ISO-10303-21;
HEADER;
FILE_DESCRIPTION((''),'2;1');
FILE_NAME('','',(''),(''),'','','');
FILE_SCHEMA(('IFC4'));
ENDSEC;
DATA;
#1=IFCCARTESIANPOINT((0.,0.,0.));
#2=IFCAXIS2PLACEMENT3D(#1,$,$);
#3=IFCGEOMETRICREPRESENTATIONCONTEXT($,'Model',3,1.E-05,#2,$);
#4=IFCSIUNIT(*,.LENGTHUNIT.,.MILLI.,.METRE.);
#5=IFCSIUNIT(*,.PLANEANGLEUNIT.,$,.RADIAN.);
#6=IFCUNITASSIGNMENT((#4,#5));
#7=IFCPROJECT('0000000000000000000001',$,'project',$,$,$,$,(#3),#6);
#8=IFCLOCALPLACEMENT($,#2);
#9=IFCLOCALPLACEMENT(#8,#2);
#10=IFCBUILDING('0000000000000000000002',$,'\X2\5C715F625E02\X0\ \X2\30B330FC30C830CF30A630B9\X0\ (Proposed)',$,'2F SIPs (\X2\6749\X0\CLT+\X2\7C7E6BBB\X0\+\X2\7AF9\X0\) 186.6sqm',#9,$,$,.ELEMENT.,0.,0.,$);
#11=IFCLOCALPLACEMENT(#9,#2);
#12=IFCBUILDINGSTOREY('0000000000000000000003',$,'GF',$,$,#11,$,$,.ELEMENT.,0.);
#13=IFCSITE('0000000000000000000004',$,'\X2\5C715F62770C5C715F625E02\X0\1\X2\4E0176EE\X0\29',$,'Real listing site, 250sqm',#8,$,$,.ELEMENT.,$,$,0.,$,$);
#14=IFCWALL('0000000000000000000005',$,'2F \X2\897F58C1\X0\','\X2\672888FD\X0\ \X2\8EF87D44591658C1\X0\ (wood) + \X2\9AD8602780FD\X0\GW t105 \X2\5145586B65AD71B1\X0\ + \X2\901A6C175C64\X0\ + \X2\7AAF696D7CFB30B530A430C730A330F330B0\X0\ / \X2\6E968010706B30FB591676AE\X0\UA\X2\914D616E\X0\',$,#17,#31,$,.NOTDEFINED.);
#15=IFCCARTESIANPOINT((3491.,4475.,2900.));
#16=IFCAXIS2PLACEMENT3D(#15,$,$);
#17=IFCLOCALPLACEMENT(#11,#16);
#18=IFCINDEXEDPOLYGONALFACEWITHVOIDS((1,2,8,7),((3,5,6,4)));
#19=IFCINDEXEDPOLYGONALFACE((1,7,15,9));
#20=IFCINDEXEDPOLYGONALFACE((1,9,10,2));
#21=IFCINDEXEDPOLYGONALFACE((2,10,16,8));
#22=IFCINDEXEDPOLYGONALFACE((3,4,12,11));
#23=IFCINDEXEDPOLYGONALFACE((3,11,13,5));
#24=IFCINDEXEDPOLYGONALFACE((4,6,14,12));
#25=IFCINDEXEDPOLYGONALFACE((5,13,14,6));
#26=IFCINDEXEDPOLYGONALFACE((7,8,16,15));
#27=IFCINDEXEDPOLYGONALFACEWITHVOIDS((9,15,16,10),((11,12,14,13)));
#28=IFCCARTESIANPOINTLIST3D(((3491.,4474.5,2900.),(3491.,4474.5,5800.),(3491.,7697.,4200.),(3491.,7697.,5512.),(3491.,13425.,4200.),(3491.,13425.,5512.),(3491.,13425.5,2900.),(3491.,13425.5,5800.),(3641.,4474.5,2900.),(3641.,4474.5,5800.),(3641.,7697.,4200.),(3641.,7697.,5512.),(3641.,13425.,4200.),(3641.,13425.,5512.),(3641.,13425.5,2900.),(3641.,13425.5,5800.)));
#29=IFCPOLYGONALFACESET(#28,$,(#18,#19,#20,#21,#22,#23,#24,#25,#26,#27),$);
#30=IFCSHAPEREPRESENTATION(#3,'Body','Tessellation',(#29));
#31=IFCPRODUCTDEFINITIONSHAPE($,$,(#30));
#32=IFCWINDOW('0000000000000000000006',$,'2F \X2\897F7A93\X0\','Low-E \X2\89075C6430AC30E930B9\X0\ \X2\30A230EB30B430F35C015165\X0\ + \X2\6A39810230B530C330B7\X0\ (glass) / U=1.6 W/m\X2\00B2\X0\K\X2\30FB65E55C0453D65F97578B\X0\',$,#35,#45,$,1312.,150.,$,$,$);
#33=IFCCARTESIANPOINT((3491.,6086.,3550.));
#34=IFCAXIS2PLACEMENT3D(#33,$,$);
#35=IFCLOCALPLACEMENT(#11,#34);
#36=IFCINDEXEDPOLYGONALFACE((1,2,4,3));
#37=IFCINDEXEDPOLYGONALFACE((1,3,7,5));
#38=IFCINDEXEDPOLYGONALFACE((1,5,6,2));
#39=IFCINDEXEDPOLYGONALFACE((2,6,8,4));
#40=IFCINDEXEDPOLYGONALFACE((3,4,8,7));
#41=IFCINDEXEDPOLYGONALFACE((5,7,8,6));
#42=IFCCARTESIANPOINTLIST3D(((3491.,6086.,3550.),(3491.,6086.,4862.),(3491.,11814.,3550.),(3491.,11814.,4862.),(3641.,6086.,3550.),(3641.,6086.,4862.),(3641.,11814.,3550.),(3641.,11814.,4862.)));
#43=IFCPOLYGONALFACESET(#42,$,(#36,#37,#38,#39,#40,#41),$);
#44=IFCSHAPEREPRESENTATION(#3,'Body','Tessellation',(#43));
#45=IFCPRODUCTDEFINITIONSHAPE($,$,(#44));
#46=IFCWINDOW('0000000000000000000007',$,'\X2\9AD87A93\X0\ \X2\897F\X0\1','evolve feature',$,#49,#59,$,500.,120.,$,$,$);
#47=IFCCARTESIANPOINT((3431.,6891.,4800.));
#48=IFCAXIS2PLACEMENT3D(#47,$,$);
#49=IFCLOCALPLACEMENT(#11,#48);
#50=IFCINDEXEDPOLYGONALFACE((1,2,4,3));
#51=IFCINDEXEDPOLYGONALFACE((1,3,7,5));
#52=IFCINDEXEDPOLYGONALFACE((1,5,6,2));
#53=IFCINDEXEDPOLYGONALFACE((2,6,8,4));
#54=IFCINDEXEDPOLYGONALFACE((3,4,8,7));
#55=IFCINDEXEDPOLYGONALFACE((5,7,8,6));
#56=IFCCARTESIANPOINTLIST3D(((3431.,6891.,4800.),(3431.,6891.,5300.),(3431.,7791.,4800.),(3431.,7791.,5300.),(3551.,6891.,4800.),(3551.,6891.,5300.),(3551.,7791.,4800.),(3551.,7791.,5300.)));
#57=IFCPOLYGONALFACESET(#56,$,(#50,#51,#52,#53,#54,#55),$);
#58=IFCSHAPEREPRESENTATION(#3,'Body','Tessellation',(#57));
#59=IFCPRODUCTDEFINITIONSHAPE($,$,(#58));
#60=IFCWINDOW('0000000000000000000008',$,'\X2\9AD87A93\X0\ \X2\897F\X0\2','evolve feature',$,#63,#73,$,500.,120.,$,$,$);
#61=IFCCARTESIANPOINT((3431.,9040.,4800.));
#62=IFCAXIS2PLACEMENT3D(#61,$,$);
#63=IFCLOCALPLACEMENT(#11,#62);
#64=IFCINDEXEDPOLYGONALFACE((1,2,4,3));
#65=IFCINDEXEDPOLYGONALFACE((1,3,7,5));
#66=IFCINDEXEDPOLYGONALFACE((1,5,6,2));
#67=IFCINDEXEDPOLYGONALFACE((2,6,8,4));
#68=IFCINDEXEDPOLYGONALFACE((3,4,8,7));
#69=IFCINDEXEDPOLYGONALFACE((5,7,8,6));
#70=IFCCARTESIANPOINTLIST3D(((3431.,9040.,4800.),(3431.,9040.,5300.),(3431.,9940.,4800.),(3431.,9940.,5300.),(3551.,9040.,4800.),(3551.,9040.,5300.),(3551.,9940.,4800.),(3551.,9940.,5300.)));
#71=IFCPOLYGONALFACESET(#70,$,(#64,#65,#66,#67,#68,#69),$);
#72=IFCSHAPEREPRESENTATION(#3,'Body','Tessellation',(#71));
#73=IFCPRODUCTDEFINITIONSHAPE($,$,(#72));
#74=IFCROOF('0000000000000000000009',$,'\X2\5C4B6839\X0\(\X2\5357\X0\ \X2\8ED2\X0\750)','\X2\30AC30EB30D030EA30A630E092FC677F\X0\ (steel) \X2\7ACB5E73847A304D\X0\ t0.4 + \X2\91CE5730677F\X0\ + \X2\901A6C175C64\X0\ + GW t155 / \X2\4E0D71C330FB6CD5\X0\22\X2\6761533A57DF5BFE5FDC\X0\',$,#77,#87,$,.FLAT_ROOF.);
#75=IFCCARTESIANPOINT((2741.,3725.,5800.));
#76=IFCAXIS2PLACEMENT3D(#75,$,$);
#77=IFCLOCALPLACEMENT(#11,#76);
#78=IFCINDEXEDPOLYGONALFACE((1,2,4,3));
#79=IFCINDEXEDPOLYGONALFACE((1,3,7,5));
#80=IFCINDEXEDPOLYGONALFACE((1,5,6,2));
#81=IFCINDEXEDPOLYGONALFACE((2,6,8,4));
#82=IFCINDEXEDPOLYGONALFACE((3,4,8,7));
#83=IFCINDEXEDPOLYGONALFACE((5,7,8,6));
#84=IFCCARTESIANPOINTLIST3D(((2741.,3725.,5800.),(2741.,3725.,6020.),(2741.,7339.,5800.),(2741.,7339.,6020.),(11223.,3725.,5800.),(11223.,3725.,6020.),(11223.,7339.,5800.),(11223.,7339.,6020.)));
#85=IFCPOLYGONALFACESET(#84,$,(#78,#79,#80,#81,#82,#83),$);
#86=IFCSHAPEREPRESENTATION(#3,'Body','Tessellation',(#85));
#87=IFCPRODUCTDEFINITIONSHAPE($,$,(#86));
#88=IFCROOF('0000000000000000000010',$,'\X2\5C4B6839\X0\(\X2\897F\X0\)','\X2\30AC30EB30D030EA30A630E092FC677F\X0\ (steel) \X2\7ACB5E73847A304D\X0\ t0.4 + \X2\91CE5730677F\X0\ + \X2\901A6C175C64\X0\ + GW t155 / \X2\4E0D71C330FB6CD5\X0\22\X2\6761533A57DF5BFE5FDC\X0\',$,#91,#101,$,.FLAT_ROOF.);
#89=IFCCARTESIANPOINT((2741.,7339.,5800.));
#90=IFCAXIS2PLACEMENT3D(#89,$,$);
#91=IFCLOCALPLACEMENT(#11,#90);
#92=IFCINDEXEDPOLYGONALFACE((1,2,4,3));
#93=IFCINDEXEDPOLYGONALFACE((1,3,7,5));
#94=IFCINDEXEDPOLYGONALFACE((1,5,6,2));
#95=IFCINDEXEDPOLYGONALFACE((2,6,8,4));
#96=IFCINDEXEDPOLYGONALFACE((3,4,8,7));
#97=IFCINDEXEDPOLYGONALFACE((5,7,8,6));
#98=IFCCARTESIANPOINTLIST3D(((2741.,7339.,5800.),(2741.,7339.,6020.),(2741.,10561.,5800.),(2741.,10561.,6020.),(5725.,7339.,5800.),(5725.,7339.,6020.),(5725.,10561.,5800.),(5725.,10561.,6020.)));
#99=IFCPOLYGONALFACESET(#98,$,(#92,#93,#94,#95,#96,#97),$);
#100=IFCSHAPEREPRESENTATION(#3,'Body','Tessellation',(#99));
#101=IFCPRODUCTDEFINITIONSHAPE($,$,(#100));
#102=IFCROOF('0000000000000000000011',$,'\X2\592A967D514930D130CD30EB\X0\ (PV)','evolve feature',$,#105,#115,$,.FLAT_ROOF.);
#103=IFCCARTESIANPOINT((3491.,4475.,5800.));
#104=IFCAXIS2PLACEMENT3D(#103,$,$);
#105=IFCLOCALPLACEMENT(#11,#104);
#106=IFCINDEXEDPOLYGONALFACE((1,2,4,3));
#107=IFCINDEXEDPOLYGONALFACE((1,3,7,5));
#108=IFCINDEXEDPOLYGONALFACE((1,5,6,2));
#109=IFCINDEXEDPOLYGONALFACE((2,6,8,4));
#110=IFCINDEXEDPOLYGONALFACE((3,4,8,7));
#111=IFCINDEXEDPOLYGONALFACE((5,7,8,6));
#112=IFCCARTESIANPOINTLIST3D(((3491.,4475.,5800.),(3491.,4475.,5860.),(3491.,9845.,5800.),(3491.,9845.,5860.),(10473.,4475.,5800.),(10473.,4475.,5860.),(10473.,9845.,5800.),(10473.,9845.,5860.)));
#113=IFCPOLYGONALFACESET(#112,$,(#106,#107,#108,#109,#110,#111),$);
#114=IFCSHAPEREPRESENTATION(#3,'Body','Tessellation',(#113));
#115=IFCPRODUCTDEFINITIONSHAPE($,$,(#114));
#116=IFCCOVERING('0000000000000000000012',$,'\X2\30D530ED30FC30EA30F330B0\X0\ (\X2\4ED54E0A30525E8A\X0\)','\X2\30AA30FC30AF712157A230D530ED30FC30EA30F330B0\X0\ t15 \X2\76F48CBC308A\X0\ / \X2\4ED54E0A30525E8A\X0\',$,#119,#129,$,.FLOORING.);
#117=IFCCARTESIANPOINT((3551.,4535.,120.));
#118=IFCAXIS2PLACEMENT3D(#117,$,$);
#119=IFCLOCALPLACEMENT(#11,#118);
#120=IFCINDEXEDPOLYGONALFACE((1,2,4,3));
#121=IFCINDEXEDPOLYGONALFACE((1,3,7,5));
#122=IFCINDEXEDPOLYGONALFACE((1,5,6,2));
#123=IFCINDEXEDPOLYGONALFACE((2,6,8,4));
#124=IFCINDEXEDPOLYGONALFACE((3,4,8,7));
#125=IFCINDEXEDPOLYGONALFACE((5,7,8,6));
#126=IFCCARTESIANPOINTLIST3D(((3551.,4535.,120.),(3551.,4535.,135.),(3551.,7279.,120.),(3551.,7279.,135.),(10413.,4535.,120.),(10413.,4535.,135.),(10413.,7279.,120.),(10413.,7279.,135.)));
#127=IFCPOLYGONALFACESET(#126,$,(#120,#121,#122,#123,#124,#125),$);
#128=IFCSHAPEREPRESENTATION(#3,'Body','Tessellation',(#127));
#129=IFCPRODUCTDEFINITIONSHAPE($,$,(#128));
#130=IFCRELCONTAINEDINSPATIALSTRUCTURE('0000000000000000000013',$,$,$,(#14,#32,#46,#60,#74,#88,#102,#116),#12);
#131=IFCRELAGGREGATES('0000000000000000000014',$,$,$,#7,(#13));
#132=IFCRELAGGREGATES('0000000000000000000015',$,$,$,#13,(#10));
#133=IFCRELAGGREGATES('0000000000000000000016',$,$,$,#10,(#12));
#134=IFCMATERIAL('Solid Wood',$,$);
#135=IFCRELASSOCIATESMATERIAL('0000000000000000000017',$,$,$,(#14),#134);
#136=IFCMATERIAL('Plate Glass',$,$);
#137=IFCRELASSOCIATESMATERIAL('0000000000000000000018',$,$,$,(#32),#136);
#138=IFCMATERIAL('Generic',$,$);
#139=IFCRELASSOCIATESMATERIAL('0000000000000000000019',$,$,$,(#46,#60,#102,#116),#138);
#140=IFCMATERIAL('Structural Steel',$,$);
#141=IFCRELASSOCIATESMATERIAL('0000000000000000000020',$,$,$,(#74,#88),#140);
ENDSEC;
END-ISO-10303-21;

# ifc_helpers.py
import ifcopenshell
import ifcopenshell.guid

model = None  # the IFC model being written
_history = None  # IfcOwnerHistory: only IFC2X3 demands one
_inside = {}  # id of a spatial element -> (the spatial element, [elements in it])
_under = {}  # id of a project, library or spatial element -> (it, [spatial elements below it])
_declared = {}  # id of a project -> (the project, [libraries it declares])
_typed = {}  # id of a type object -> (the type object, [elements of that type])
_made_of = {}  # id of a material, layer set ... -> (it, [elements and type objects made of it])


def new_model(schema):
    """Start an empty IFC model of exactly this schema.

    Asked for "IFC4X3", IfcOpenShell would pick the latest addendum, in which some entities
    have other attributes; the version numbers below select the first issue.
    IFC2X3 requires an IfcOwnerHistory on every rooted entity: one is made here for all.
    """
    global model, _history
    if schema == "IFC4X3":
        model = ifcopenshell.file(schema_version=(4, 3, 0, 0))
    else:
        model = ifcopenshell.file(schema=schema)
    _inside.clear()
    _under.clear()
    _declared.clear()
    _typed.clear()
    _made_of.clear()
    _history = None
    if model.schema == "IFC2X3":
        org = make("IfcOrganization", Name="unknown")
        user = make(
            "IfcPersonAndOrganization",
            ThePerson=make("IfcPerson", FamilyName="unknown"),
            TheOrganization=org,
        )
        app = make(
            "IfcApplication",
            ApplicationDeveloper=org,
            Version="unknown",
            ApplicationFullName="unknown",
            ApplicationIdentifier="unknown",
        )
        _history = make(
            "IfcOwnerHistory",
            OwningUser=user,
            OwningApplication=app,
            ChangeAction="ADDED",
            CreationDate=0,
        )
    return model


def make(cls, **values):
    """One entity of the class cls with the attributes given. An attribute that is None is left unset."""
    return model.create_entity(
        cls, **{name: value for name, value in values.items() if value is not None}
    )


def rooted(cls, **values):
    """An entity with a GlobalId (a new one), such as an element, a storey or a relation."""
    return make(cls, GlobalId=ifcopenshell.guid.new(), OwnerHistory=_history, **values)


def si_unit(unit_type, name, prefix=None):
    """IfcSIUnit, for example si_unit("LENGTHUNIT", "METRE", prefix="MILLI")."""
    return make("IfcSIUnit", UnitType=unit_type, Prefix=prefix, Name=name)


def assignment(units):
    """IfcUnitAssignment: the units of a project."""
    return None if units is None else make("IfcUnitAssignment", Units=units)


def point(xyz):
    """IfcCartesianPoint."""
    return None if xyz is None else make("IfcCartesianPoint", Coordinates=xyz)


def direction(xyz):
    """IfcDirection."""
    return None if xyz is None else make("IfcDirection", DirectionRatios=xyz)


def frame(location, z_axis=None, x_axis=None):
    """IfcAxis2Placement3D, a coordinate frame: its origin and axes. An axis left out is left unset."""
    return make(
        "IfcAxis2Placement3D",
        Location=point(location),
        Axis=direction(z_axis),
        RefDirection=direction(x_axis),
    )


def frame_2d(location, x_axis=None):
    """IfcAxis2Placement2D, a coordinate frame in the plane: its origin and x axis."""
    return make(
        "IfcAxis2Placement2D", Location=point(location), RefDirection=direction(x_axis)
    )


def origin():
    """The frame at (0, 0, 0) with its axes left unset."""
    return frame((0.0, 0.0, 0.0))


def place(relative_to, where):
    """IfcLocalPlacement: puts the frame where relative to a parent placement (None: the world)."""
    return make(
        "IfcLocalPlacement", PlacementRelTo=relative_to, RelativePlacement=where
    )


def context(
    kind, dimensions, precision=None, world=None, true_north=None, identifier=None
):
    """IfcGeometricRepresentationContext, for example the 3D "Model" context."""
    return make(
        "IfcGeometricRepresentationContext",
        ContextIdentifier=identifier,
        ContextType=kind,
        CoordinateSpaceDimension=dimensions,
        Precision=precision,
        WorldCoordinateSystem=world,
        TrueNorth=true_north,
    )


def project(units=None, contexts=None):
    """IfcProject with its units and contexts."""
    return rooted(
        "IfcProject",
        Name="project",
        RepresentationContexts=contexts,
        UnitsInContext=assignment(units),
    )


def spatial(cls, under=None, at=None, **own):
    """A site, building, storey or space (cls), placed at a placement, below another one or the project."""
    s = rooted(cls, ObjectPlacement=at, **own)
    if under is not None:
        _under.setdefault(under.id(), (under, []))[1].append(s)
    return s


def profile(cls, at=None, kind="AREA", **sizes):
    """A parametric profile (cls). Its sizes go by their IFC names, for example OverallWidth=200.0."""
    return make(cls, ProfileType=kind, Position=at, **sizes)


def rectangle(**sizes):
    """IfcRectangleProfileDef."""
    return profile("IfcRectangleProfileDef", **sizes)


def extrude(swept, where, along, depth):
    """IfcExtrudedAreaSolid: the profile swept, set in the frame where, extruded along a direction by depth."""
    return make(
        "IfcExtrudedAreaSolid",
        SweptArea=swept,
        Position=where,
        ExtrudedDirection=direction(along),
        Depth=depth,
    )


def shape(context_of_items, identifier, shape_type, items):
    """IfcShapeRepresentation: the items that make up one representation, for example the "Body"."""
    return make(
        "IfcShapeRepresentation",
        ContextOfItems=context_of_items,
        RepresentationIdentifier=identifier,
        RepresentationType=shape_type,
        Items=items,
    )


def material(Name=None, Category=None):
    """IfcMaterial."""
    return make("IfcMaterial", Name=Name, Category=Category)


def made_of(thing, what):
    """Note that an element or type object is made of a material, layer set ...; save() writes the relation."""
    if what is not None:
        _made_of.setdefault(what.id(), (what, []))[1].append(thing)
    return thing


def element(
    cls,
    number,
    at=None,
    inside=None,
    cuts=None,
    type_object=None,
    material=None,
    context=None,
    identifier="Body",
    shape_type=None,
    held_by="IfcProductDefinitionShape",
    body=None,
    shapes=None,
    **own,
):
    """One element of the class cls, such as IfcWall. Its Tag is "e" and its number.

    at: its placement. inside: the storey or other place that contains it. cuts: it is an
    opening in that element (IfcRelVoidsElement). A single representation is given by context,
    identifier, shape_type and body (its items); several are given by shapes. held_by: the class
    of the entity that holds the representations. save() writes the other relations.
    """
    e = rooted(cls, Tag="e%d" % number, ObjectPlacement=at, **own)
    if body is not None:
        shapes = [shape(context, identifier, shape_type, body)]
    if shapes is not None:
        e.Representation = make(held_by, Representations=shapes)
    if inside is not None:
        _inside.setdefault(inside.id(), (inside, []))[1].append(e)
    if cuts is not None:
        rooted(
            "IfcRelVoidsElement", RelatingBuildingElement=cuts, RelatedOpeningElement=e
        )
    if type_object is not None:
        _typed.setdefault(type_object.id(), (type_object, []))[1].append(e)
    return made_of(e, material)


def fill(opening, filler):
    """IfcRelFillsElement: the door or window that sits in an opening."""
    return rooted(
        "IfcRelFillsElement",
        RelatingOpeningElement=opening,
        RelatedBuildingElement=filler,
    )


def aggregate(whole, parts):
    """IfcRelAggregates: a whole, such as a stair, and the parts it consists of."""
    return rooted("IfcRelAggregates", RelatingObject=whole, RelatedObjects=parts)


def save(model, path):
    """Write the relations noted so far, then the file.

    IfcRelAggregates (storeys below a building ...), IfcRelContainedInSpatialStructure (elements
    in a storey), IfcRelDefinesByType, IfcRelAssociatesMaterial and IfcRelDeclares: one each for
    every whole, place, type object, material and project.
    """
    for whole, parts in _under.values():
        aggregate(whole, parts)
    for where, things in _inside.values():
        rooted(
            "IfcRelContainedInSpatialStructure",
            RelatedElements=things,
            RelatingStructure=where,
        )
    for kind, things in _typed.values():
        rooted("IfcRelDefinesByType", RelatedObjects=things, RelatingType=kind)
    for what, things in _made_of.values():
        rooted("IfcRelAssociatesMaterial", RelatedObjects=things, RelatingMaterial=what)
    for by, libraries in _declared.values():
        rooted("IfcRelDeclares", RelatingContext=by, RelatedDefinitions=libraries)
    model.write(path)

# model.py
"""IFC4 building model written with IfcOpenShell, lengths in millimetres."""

from ifc_helpers import new_model, si_unit, frame, frame_2d, origin, place, context, project, spatial, rectangle, extrude, material, element, fill, save


model = new_model("IFC4")

# Units and contexts
model_context = context("Model", 3, precision=1e-05, world=origin())
ifc_project = project(units=[si_unit("LENGTHUNIT", "METRE", prefix="MILLI"), si_unit("PLANEANGLEUNIT", "RADIAN")], contexts=[model_context])

# Site, building, storey
site_placement = place(None, origin())
site = spatial("IfcSite", under=ifc_project, at=site_placement, Name="山形県山形市1丁目29", ObjectType="Real listing site, 250sqm", CompositionType="ELEMENT", RefElevation=0.0)
building_placement = place(site_placement, origin())
building = spatial("IfcBuilding", under=site, at=building_placement, Name="山形市 コートハウス (Proposed)", ObjectType="2F SIPs (杉CLT+籾殻+竹) 186.6sqm", CompositionType="ELEMENT", ElevationOfRefHeight=0.0, ElevationOfTerrain=0.0)
storey_placement = place(building_placement, origin())
storey = spatial("IfcBuildingStorey", under=building, at=storey_placement, Name="GF", CompositionType="ELEMENT", Elevation=0.0)

# Shared definitions
ifc_material_1 = material(Name="Solid Wood")
ifc_material_2 = material(Name="Generic")

# Shared definitions
ifc_material_3 = material(Name="Plate Glass")

# Wall, openings, windows
wall_1_placement = place(storey_placement, frame((3491.0, 4475.0, 2900.0)))
wall_1 = element("IfcWall", 1, at=wall_1_placement, inside=storey, material=ifc_material_1, Name="2F 西壁", Description="木製 軸組外壁 (wood) + 高性能GW t105 充填断熱 + 通気層 + 窯業系サイディング / 準耐火・外皮UA配慮", PredefinedType="NOTDEFINED", context=model_context, shape_type="SweptSolid", body=[
    extrude(rectangle(XDim=150.0, YDim=8951.0, at=frame_2d((75.0, 4475.0))), frame((3491.0, 4475.0, 2900.0)), (0.0, 0.0, 1.0), 2900.0),
])
opening_1_placement = place(storey_placement, frame((3491.0, 6086.0, 3550.0)))
opening_1 = element("IfcOpeningElement", 2, at=opening_1_placement, cuts=wall_1, PredefinedType="NOTDEFINED", context=model_context, shape_type="SweptSolid", body=[
    extrude(rectangle(XDim=150.0, YDim=5728.0, at=frame_2d((75.0, 2864.0))), frame((3491.0, 6086.0, 3550.0)), (0.0, 0.0, 1.0), 1312.0),
])
opening_2_placement = place(storey_placement, frame((3431.0, 6891.0, 4800.0)))
opening_2 = element("IfcOpeningElement", 3, at=opening_2_placement, cuts=wall_1, PredefinedType="NOTDEFINED", context=model_context, shape_type="SweptSolid", body=[
    extrude(rectangle(XDim=120.0, YDim=900.0, at=frame_2d((60.0, 450.0))), frame((3431.0, 6891.0, 4800.0)), (0.0, 0.0, 1.0), 500.0),
])
opening_3_placement = place(storey_placement, frame((3431.0, 9040.0, 4800.0)))
opening_3 = element("IfcOpeningElement", 4, at=opening_3_placement, cuts=wall_1, PredefinedType="NOTDEFINED", context=model_context, shape_type="SweptSolid", body=[
    extrude(rectangle(XDim=120.0, YDim=900.0, at=frame_2d((60.0, 450.0))), frame((3431.0, 9040.0, 4800.0)), (0.0, 0.0, 1.0), 500.0),
])
window_1_placement = place(storey_placement, frame((3491.0, 6086.0, 3550.0)))
window_1 = element("IfcWindow", 5, at=window_1_placement, inside=storey, material=ifc_material_3, Name="2F 西窓", Description="Low-E 複層ガラス アルゴン封入 + 樹脂サッシ (glass) / U=1.6 W/m²K・日射取得型", OverallHeight=1312.0, OverallWidth=150.0, context=model_context, shape_type="SweptSolid", body=[
    extrude(rectangle(XDim=150.0, YDim=5728.0, at=frame_2d((75.0, 2864.0))), frame((3491.0, 6086.0, 3550.0)), (0.0, 0.0, 1.0), 1312.0),
])
fill(opening_1, window_1)
window_2_placement = place(storey_placement, frame((3431.0, 6891.0, 4800.0)))
window_2 = element("IfcWindow", 6, at=window_2_placement, inside=storey, material=ifc_material_2, Name="高窓 西1", Description="evolve feature", OverallHeight=500.0, OverallWidth=120.0, context=model_context, shape_type="SweptSolid", body=[
    extrude(rectangle(XDim=120.0, YDim=900.0, at=frame_2d((60.0, 450.0))), frame((3431.0, 6891.0, 4800.0)), (0.0, 0.0, 1.0), 500.0),
])
fill(opening_2, window_2)
window_3_placement = place(storey_placement, frame((3431.0, 9040.0, 4800.0)))
window_3 = element("IfcWindow", 7, at=window_3_placement, inside=storey, material=ifc_material_2, Name="高窓 西2", Description="evolve feature", OverallHeight=500.0, OverallWidth=120.0, context=model_context, shape_type="SweptSolid", body=[
    extrude(rectangle(XDim=120.0, YDim=900.0, at=frame_2d((60.0, 450.0))), frame((3431.0, 9040.0, 4800.0)), (0.0, 0.0, 1.0), 500.0),
])
fill(opening_3, window_3)

# Roofs
ifc_material_4 = material(Name="Structural Steel")
roof_1_placement = place(storey_placement, frame((2741.0, 3725.0, 5800.0)))
element("IfcRoof", 8, at=roof_1_placement, inside=storey, material=ifc_material_4, Name="屋根(南 軒750)", Description="ガルバリウム鋼板 (steel) 立平葺き t0.4 + 野地板 + 通気層 + GW t155 / 不燃・法22条区域対応", PredefinedType="FLAT_ROOF", context=model_context, shape_type="SweptSolid", body=[
    extrude(rectangle(XDim=8482.0, YDim=3614.0, at=frame_2d((4241.0, 1807.0))), frame((2741.0, 3725.0, 5800.0)), (0.0, 0.0, 1.0), 220.0),
])
roof_2_placement = place(storey_placement, frame((2741.0, 7339.0, 5800.0)))
element("IfcRoof", 9, at=roof_2_placement, inside=storey, material=ifc_material_4, Name="屋根(西)", Description="ガルバリウム鋼板 (steel) 立平葺き t0.4 + 野地板 + 通気層 + GW t155 / 不燃・法22条区域対応", PredefinedType="FLAT_ROOF", context=model_context, shape_type="SweptSolid", body=[
    extrude(rectangle(XDim=2984.0, YDim=3222.0, at=frame_2d((1492.0, 1611.0))), frame((2741.0, 7339.0, 5800.0)), (0.0, 0.0, 1.0), 220.0),
])
roof_3_placement = place(storey_placement, frame((3491.0, 4475.0, 5800.0)))
element("IfcRoof", 10, at=roof_3_placement, inside=storey, material=ifc_material_2, Name="太陽光パネル (PV)", Description="evolve feature", PredefinedType="FLAT_ROOF", context=model_context, shape_type="SweptSolid", body=[
    extrude(rectangle(XDim=6982.0, YDim=5370.0, at=frame_2d((3491.0, 2685.0))), frame((3491.0, 4475.0, 5800.0)), (0.0, 0.0, 1.0), 60.0),
])

# Covering
covering_placement = place(storey_placement, frame((3551.0, 4535.0, 120.0)))
element("IfcCovering", 11, at=covering_placement, inside=storey, material=ifc_material_2, Name="フローリング (仕上げ床)", Description="オーク無垢フローリング t15 直貼り / 仕上げ床", PredefinedType="FLOORING", context=model_context, shape_type="SweptSolid", body=[
    extrude(rectangle(XDim=6862.0, YDim=2744.0, at=frame_2d((3431.0, 1372.0))), frame((3551.0, 4535.0, 120.0)), (0.0, 0.0, 1.0), 15.0),
])

save(model, "model.ifc")
